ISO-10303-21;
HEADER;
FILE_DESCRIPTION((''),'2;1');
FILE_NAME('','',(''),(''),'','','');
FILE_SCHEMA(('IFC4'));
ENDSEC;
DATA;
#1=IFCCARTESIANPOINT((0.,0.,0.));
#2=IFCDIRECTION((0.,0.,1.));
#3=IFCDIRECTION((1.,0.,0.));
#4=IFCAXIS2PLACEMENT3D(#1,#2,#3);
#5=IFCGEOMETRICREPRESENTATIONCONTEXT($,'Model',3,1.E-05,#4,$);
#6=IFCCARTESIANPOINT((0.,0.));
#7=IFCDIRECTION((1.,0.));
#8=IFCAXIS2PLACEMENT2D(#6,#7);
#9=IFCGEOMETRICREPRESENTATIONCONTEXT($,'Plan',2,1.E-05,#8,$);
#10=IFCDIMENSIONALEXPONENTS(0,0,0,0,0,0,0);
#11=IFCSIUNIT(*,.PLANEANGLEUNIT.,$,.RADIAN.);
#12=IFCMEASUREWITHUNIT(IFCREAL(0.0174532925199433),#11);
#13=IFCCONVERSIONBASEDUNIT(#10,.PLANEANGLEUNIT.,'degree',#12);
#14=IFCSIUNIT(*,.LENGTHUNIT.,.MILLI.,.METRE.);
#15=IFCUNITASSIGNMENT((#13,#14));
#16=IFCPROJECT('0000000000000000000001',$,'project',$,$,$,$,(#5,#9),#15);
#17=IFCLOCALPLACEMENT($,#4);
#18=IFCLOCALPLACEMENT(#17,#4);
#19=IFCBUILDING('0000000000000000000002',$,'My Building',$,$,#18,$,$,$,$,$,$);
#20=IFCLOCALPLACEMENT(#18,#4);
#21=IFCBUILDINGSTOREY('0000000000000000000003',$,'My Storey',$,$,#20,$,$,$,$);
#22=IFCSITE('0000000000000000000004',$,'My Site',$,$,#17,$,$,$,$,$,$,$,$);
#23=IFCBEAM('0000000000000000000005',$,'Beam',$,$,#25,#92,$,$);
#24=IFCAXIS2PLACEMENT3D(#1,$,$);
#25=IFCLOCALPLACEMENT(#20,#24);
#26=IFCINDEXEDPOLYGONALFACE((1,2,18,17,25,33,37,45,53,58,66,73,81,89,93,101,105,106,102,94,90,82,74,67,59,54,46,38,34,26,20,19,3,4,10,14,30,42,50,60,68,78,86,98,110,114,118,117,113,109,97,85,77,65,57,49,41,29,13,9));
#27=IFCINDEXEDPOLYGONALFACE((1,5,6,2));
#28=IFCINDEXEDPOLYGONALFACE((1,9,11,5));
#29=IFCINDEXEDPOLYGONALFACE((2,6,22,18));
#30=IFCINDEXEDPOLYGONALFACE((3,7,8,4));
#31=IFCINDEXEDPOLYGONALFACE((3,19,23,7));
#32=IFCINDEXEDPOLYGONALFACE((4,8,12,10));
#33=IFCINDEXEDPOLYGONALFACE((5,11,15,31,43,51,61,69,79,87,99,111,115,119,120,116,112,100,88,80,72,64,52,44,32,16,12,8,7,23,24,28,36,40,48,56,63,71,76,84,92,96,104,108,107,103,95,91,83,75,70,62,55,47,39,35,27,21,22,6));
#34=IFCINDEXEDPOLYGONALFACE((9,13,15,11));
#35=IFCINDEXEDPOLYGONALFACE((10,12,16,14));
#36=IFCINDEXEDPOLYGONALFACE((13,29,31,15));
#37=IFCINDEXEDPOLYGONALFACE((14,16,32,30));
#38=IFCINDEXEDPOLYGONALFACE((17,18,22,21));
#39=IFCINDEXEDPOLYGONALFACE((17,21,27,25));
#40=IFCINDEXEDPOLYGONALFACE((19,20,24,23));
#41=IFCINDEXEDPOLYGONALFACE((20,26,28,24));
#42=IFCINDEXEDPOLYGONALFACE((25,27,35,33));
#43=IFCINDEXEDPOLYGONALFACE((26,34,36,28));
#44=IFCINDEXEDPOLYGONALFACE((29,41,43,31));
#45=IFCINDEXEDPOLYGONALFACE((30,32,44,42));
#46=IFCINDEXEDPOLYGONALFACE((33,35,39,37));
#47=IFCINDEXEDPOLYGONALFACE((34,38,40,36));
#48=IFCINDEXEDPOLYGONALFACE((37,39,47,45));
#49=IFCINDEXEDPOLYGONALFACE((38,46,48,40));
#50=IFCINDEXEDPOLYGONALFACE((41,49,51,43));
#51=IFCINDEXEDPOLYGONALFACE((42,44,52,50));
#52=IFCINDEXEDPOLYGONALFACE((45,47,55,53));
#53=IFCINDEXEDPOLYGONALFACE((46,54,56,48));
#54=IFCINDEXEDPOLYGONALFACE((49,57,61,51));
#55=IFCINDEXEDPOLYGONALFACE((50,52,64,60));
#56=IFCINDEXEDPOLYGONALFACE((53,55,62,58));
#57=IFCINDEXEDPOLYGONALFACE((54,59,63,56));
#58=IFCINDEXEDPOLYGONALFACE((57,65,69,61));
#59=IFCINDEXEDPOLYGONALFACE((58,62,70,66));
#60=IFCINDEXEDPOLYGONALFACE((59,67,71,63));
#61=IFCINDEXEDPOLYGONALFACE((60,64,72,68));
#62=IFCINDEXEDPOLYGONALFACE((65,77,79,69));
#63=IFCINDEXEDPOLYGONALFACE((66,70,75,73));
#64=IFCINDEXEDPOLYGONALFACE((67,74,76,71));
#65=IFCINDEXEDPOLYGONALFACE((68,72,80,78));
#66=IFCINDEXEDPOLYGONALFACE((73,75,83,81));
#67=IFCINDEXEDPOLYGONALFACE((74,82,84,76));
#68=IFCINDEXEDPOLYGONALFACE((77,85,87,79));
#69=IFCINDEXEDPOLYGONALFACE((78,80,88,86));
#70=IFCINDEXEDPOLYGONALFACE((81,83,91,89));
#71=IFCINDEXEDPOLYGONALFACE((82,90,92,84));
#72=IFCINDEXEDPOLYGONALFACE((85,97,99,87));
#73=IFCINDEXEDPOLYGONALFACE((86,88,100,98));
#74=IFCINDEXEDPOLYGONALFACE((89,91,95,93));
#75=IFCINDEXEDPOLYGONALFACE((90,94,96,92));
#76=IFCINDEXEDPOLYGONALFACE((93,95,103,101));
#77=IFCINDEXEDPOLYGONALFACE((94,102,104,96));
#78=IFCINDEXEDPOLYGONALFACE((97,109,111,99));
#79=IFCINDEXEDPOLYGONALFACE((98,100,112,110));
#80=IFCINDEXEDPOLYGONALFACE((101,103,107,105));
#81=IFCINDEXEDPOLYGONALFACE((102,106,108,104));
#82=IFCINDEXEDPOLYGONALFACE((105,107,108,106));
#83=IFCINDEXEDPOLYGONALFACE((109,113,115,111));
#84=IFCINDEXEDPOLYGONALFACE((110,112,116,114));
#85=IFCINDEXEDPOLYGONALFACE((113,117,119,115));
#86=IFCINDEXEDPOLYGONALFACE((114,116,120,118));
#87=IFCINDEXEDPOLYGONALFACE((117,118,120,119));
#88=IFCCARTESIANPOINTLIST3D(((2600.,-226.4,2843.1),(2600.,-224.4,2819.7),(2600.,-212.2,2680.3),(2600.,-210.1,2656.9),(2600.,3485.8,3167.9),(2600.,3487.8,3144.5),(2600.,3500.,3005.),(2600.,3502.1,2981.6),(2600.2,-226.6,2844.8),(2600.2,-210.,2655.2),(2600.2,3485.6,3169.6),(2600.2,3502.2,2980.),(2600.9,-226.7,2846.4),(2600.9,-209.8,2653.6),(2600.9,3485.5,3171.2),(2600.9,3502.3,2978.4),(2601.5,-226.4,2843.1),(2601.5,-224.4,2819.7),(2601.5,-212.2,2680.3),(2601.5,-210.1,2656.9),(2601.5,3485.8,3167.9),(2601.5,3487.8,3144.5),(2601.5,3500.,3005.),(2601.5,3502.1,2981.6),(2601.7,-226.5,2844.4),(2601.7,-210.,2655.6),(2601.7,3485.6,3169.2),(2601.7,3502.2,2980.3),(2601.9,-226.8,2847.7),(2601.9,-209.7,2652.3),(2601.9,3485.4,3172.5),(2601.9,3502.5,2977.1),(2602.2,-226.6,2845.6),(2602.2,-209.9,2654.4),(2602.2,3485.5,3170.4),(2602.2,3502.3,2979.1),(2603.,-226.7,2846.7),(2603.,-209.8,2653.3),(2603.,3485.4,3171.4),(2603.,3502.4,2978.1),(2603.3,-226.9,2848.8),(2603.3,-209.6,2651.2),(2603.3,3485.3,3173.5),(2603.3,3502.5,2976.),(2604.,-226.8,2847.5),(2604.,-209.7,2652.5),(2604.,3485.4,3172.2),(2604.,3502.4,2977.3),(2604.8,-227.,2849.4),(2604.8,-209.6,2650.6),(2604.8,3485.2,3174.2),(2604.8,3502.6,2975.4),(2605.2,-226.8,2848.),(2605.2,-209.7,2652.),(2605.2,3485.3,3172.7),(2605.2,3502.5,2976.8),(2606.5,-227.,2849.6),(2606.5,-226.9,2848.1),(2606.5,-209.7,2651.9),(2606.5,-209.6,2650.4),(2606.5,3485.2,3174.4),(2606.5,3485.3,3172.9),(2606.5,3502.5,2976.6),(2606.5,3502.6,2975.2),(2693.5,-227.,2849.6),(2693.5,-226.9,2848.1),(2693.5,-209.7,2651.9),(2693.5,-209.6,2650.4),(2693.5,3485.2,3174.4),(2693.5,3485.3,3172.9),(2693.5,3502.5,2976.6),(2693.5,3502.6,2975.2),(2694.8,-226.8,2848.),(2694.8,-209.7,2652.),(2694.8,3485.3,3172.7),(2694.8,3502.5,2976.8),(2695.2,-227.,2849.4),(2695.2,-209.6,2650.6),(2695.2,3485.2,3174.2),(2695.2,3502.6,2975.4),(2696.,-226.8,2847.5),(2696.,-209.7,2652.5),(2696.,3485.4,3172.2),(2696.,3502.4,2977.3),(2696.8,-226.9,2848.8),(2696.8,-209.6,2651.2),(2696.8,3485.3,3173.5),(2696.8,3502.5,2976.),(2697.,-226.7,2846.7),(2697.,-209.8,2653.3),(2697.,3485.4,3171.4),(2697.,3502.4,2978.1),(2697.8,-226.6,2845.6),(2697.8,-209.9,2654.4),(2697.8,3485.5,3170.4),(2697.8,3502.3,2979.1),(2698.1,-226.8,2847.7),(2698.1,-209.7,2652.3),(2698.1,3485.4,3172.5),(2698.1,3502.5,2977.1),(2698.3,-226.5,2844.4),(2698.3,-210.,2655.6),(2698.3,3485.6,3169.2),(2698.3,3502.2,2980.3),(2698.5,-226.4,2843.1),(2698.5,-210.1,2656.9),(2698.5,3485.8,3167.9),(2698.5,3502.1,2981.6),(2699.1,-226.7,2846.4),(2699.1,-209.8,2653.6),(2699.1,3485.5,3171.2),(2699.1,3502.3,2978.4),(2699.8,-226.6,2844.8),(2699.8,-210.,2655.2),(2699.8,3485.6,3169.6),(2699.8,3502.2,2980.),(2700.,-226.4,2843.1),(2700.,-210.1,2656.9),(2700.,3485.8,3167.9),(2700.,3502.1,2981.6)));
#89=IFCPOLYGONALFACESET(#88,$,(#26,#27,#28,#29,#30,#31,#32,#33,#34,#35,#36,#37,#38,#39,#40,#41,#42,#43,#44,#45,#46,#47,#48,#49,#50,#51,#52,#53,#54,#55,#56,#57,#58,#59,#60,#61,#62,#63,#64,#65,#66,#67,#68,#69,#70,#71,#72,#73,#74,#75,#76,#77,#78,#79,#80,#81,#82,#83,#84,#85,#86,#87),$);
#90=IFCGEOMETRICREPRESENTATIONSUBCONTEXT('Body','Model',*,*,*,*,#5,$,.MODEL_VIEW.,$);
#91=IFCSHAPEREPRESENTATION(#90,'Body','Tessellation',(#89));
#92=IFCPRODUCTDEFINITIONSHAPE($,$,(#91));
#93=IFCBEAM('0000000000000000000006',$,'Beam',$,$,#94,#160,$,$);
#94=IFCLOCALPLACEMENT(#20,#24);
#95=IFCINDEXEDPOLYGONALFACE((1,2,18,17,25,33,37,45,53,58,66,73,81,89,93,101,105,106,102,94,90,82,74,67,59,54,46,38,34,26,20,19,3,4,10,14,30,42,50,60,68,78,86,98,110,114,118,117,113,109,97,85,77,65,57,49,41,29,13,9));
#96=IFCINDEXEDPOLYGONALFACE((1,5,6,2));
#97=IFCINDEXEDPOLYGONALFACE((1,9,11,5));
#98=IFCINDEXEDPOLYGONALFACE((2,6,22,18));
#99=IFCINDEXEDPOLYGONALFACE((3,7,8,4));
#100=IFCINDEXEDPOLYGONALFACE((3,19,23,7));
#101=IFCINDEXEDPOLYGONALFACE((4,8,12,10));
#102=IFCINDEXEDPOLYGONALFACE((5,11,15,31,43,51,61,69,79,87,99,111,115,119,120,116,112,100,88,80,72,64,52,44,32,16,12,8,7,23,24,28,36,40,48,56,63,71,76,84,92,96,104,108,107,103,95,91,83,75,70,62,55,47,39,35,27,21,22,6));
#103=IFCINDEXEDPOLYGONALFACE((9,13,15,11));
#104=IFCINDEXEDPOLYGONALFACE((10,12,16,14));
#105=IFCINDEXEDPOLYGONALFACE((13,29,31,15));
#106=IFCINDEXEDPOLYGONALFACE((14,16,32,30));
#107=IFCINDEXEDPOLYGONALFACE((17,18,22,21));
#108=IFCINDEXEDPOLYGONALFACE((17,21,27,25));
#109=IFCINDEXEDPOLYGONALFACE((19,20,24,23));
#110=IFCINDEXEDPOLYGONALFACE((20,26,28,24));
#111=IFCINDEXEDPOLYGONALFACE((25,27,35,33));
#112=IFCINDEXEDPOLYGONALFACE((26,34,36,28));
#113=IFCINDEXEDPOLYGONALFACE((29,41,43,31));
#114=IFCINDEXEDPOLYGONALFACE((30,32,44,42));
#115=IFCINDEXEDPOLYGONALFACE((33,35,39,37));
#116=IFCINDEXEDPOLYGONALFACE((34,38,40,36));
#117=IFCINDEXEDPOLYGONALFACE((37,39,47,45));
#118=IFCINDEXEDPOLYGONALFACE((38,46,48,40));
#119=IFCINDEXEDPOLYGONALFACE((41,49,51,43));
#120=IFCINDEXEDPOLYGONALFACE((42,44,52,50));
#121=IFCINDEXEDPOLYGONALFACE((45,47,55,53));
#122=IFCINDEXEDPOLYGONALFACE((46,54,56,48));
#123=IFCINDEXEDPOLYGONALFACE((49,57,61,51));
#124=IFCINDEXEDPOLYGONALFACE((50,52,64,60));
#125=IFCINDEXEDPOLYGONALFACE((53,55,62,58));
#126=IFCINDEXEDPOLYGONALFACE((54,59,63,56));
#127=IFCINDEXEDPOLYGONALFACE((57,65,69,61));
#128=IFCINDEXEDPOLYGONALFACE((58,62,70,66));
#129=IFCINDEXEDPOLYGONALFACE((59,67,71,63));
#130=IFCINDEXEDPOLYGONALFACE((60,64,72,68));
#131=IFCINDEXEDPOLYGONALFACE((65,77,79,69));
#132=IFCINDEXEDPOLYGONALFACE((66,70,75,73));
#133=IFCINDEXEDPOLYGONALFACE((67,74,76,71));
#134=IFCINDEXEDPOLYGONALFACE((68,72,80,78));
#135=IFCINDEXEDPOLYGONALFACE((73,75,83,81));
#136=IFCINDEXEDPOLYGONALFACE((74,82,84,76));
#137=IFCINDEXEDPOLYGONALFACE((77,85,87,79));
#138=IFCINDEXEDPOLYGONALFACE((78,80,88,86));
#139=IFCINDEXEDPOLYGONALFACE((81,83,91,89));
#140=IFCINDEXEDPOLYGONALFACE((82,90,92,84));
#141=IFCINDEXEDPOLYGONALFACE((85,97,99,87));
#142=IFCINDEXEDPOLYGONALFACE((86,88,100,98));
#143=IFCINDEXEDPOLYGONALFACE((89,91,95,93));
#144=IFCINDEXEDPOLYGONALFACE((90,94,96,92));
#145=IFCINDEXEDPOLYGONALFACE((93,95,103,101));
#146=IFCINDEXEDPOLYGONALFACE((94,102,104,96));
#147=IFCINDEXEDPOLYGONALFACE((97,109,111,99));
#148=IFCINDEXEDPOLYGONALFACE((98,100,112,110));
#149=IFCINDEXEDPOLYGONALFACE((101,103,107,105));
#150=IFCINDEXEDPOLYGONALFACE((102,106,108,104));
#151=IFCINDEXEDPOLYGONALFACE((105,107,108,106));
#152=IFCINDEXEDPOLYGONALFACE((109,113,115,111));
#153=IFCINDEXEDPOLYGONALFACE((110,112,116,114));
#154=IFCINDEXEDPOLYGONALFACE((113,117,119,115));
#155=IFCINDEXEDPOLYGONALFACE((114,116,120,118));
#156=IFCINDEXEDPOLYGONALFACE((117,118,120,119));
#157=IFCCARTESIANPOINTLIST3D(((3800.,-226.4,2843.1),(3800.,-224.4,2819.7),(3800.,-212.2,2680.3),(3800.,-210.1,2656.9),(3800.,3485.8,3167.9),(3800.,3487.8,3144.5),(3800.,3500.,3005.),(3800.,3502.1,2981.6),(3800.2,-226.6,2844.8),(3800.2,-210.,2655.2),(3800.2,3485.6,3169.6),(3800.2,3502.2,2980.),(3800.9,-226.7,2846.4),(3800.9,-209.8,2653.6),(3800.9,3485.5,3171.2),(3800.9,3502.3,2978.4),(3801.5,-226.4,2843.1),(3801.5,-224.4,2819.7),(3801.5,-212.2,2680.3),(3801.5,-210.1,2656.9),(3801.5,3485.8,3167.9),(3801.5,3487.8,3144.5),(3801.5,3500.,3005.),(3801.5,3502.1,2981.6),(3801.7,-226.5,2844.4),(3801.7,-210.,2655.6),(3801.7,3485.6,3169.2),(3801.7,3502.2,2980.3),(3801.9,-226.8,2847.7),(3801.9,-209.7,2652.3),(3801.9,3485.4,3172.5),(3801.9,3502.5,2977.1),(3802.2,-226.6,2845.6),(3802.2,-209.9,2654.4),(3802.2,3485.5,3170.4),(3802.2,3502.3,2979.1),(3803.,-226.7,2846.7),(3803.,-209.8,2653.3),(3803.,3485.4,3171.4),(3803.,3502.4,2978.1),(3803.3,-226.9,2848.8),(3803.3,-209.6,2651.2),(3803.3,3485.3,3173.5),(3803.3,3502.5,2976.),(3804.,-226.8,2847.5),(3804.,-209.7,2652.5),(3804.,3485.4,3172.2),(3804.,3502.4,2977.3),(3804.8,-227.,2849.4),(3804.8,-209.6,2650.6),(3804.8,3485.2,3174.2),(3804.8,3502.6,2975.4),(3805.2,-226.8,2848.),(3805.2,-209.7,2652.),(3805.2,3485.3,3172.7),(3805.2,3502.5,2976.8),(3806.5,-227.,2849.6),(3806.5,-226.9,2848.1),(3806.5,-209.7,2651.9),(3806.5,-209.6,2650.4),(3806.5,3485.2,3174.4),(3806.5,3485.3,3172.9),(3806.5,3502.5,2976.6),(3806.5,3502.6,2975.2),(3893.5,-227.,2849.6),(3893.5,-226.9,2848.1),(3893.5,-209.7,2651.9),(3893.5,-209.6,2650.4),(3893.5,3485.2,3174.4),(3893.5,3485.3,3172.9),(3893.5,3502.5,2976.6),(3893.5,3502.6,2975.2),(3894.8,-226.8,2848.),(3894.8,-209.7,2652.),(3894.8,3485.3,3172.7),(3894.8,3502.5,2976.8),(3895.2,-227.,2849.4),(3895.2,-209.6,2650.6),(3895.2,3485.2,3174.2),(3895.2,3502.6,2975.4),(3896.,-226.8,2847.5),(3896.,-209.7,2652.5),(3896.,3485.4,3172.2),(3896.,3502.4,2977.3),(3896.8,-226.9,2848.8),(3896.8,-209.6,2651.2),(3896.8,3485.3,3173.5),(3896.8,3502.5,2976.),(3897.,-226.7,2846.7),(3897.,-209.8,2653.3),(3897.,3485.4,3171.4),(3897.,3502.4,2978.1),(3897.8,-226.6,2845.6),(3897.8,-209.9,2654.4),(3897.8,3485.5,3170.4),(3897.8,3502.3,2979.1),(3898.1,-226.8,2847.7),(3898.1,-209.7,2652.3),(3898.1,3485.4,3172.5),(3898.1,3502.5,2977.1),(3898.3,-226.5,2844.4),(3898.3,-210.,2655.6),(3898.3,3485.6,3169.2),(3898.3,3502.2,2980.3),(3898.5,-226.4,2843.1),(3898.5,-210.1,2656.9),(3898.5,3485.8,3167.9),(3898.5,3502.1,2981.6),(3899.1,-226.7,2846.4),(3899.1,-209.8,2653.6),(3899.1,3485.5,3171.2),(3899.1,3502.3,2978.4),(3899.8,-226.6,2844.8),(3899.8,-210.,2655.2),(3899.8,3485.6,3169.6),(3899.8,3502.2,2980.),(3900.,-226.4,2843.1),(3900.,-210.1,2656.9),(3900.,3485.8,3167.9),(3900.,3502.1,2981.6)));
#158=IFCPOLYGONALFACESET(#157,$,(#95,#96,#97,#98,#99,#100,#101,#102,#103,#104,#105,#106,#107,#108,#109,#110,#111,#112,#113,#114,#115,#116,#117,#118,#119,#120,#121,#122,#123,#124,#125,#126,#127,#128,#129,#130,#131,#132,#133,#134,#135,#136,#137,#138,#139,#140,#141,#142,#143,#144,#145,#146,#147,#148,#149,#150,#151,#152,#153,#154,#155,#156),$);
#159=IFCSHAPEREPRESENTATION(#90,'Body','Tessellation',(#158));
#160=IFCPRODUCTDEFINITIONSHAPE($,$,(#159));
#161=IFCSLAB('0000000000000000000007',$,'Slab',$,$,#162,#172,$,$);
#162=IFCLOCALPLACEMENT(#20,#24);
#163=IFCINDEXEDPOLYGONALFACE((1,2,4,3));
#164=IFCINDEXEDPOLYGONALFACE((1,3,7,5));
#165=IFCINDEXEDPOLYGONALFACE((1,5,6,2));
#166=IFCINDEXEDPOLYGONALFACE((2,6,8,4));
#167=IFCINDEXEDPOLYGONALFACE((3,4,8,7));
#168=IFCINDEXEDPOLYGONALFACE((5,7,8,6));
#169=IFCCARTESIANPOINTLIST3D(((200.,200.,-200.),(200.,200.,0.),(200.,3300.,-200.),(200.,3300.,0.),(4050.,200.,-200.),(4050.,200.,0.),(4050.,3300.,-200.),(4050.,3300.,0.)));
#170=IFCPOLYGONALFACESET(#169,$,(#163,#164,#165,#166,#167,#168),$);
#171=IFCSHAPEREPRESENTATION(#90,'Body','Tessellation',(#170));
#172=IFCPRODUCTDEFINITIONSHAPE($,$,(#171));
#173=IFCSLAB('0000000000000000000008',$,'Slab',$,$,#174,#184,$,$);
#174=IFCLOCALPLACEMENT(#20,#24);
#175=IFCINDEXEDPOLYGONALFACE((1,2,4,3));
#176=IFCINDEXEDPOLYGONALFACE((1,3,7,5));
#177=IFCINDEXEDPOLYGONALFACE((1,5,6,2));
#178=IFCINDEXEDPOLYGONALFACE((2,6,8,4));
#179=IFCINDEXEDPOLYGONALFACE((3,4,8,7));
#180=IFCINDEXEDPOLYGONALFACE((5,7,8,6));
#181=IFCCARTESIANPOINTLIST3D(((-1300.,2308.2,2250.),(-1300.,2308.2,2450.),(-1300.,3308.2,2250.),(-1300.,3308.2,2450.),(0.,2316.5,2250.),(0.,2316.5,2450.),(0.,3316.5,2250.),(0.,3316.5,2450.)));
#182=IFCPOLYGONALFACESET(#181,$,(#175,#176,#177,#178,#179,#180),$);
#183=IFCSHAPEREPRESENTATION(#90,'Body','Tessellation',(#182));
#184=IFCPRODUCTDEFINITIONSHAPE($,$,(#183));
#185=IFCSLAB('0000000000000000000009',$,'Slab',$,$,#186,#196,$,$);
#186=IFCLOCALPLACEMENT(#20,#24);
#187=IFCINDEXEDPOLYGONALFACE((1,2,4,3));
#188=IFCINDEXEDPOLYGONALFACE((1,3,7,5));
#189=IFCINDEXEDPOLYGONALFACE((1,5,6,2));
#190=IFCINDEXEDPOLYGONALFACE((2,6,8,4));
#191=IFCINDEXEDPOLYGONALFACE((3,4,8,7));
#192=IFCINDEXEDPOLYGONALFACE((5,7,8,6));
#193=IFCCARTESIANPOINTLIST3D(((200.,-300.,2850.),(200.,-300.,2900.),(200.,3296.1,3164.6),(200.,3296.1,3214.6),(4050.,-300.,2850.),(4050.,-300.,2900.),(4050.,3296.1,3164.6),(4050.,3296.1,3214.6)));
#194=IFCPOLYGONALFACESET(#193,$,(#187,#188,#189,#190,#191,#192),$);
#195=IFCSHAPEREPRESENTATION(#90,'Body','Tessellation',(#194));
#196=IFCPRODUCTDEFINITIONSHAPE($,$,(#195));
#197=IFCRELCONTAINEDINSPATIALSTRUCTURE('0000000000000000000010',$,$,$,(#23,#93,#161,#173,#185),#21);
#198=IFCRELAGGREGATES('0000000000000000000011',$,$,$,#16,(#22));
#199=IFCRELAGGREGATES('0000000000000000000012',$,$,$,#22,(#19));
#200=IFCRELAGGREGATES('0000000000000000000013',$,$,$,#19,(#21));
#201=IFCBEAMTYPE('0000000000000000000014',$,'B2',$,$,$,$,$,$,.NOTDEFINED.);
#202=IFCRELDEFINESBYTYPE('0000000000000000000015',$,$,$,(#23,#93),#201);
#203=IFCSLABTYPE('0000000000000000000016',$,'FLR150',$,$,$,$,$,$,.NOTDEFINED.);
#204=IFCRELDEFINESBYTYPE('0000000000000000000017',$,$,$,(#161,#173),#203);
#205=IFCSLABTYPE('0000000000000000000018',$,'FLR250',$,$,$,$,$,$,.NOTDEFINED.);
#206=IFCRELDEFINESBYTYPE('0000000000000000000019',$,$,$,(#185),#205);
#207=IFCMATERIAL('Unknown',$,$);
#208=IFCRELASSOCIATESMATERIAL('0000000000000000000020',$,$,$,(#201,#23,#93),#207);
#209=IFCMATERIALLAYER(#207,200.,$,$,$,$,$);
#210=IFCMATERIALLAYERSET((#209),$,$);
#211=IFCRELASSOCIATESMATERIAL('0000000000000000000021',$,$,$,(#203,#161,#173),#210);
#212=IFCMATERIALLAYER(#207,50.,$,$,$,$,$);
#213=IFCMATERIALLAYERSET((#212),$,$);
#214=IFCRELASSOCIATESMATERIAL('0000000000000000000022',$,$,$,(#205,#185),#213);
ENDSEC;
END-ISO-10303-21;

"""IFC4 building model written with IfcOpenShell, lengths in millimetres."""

from ifc_helpers import new_model, entity, si_unit, converted_unit, frame, origin_with_axes, origin_2d_with_axis, place, context, subcontext, project, spatial, line, indexed_curve, c_section, outline, extrude, material, layer, layer_set, layer_usage, material_profile, profile_set, profile_usage, type_object, element, save


model = new_model("IFC4")

# Units and contexts
model_context = context("Model", 3, precision=1e-05, world=origin_with_axes())
plan_context = context("Plan", 2, precision=1e-05, world=origin_2d_with_axis())
body_context = subcontext(model_context, "Body", "Model", "MODEL_VIEW")
ifc_project = project(units=[converted_unit("PLANEANGLEUNIT", "degree", entity("IfcReal", 0.0174532925199433), si_unit("PLANEANGLEUNIT", "RADIAN"), dimensions=[0, 0, 0, 0, 0, 0, 0]), si_unit("LENGTHUNIT", "METRE", prefix="MILLI")], contexts=[model_context, plan_context])

# Site, building, storey
site_placement = place(None, origin_with_axes())
site = spatial("IfcSite", under=ifc_project, at=site_placement, Name="My Site")
building_placement = place(site_placement, origin_with_axes())
building = spatial("IfcBuilding", under=site, at=building_placement, Name="My Building")
storey_placement = place(building_placement, origin_with_axes())
storey = spatial("IfcBuildingStorey", under=building, at=storey_placement, Name="My Storey")

# Shared definitions
ifc_material = material(Name="Unknown")

# Beams
ifc_material_profile_1 = material_profile(ifc_material, c_section(Depth=200.0, Width=100.0, WallThickness=1.5, Girth=30.0, InternalFilletRadius=5.0))
ifc_profile_set_1 = profile_set([ifc_material_profile_1])
beam_type_1 = type_object("IfcBeamType", Name="B2", PredefinedType="NOTDEFINED", material=ifc_profile_set_1)
ifc_profile_usage_1 = profile_usage(ifc_profile_set_1, cardinal=5)
beam_1_placement = place(storey_placement, frame((2650.0, -218.3, 2750.0), z_axis=(0.0, 0.996195, 0.087156), x_axis=(-1.0, 0.0, 0.0)))
element("IfcBeam", 1, at=beam_1_placement, inside=storey, type_object=beam_type_1, material=ifc_profile_usage_1, Name="Beam", context=body_context, shape_type="SweptSolid", body=[
    extrude(c_section(Depth=200.0, Width=100.0, WallThickness=1.5, Girth=30.0, InternalFilletRadius=5.0), origin_with_axes(), (0.0, 0.0, 1.0), 3726.4),
])
ifc_profile_usage_2 = profile_usage(ifc_profile_set_1, cardinal=5)
beam_2_placement = place(storey_placement, frame((3850.0, -218.3, 2750.0), z_axis=(0.0, 0.996195, 0.087156), x_axis=(-1.0, 0.0, 0.0)))
element("IfcBeam", 2, at=beam_2_placement, inside=storey, type_object=beam_type_1, material=ifc_profile_usage_2, Name="Beam", context=body_context, shape_type="SweptSolid", body=[
    extrude(c_section(Depth=200.0, Width=100.0, WallThickness=1.5, Girth=30.0, InternalFilletRadius=5.0), origin_with_axes(), (0.0, 0.0, 1.0), 3726.4),
])

# Slabs
ifc_layer_1 = layer(ifc_material, 200.0)
ifc_layer_set_1 = layer_set([ifc_layer_1])
ifc_layer_usage_1 = layer_usage(ifc_layer_set_1, "AXIS3", "POSITIVE", 0.0)
slab_type_1 = type_object("IfcSlabType", Name="FLR150", PredefinedType="NOTDEFINED", material=ifc_layer_set_1)
slab_1_placement = place(storey_placement, frame((200.0, 200.0, -200.0), z_axis=(0.0, 0.0, 1.0), x_axis=(1.0, 0.0, 0.0)))
element("IfcSlab", 3, at=slab_1_placement, inside=storey, type_object=slab_type_1, material=ifc_layer_usage_1, Name="Slab", context=body_context, shape_type="SweptSolid", body=[
    extrude(outline(indexed_curve([(0.0, 0.0), (3850.0, 0.0), (3850.0, 3100.0), (0.0, 3100.0)], segments=[line(3, 2), line(2, 1), line(1, 4), line(4, 3)], self_intersect=False)), None, (0.0, 0.0, 1.0), 200.0),
])
ifc_layer_usage_2 = layer_usage(ifc_layer_set_1, "AXIS3", "POSITIVE", 0.0)
slab_2_placement = place(storey_placement, frame((-1300.0, 2308.2, 2250.0), z_axis=(0.0, 0.0, 1.0), x_axis=(1.0, 0.0, 0.0)))
element("IfcSlab", 4, at=slab_2_placement, inside=storey, type_object=slab_type_1, material=ifc_layer_usage_2, Name="Slab", context=body_context, shape_type="SweptSolid", body=[
    extrude(outline(indexed_curve([(0.0, 0.0), (1300.0, 8.2), (1300.0, 1008.2), (0.0, 1000.0)], segments=[line(4, 1), line(1, 2), line(2, 3), line(3, 4)], self_intersect=False)), None, (0.0, 0.0, 1.0), 200.0),
])
ifc_layer_2 = layer(ifc_material, 50.0)
ifc_layer_set_2 = layer_set([ifc_layer_2])
ifc_layer_usage_3 = layer_usage(ifc_layer_set_2, "AXIS3", "POSITIVE", 0.0)
slab_type_2 = type_object("IfcSlabType", Name="FLR250", PredefinedType="NOTDEFINED", material=ifc_layer_set_2)
slab_3_placement = place(storey_placement, frame((200.0, -300.0, 2850.0), z_axis=(0.0, -0.087156, 0.996195), x_axis=(1.0, 0.0, 0.0)))
element("IfcSlab", 5, at=slab_3_placement, inside=storey, type_object=slab_type_2, material=ifc_layer_usage_3, Name="Slab", context=body_context, shape_type="SweptSolid", body=[
    extrude(outline(indexed_curve([(0.0, 3609.8), (0.0, 0.0), (3850.0, 0.0), (3850.0, 3609.8)], segments=[line(3, 2), line(2, 1), line(1, 4), line(4, 3)], self_intersect=False)), None, (0.0, 0.087156, 0.996195), 50.0),
])

save(model, "model.ifc")
